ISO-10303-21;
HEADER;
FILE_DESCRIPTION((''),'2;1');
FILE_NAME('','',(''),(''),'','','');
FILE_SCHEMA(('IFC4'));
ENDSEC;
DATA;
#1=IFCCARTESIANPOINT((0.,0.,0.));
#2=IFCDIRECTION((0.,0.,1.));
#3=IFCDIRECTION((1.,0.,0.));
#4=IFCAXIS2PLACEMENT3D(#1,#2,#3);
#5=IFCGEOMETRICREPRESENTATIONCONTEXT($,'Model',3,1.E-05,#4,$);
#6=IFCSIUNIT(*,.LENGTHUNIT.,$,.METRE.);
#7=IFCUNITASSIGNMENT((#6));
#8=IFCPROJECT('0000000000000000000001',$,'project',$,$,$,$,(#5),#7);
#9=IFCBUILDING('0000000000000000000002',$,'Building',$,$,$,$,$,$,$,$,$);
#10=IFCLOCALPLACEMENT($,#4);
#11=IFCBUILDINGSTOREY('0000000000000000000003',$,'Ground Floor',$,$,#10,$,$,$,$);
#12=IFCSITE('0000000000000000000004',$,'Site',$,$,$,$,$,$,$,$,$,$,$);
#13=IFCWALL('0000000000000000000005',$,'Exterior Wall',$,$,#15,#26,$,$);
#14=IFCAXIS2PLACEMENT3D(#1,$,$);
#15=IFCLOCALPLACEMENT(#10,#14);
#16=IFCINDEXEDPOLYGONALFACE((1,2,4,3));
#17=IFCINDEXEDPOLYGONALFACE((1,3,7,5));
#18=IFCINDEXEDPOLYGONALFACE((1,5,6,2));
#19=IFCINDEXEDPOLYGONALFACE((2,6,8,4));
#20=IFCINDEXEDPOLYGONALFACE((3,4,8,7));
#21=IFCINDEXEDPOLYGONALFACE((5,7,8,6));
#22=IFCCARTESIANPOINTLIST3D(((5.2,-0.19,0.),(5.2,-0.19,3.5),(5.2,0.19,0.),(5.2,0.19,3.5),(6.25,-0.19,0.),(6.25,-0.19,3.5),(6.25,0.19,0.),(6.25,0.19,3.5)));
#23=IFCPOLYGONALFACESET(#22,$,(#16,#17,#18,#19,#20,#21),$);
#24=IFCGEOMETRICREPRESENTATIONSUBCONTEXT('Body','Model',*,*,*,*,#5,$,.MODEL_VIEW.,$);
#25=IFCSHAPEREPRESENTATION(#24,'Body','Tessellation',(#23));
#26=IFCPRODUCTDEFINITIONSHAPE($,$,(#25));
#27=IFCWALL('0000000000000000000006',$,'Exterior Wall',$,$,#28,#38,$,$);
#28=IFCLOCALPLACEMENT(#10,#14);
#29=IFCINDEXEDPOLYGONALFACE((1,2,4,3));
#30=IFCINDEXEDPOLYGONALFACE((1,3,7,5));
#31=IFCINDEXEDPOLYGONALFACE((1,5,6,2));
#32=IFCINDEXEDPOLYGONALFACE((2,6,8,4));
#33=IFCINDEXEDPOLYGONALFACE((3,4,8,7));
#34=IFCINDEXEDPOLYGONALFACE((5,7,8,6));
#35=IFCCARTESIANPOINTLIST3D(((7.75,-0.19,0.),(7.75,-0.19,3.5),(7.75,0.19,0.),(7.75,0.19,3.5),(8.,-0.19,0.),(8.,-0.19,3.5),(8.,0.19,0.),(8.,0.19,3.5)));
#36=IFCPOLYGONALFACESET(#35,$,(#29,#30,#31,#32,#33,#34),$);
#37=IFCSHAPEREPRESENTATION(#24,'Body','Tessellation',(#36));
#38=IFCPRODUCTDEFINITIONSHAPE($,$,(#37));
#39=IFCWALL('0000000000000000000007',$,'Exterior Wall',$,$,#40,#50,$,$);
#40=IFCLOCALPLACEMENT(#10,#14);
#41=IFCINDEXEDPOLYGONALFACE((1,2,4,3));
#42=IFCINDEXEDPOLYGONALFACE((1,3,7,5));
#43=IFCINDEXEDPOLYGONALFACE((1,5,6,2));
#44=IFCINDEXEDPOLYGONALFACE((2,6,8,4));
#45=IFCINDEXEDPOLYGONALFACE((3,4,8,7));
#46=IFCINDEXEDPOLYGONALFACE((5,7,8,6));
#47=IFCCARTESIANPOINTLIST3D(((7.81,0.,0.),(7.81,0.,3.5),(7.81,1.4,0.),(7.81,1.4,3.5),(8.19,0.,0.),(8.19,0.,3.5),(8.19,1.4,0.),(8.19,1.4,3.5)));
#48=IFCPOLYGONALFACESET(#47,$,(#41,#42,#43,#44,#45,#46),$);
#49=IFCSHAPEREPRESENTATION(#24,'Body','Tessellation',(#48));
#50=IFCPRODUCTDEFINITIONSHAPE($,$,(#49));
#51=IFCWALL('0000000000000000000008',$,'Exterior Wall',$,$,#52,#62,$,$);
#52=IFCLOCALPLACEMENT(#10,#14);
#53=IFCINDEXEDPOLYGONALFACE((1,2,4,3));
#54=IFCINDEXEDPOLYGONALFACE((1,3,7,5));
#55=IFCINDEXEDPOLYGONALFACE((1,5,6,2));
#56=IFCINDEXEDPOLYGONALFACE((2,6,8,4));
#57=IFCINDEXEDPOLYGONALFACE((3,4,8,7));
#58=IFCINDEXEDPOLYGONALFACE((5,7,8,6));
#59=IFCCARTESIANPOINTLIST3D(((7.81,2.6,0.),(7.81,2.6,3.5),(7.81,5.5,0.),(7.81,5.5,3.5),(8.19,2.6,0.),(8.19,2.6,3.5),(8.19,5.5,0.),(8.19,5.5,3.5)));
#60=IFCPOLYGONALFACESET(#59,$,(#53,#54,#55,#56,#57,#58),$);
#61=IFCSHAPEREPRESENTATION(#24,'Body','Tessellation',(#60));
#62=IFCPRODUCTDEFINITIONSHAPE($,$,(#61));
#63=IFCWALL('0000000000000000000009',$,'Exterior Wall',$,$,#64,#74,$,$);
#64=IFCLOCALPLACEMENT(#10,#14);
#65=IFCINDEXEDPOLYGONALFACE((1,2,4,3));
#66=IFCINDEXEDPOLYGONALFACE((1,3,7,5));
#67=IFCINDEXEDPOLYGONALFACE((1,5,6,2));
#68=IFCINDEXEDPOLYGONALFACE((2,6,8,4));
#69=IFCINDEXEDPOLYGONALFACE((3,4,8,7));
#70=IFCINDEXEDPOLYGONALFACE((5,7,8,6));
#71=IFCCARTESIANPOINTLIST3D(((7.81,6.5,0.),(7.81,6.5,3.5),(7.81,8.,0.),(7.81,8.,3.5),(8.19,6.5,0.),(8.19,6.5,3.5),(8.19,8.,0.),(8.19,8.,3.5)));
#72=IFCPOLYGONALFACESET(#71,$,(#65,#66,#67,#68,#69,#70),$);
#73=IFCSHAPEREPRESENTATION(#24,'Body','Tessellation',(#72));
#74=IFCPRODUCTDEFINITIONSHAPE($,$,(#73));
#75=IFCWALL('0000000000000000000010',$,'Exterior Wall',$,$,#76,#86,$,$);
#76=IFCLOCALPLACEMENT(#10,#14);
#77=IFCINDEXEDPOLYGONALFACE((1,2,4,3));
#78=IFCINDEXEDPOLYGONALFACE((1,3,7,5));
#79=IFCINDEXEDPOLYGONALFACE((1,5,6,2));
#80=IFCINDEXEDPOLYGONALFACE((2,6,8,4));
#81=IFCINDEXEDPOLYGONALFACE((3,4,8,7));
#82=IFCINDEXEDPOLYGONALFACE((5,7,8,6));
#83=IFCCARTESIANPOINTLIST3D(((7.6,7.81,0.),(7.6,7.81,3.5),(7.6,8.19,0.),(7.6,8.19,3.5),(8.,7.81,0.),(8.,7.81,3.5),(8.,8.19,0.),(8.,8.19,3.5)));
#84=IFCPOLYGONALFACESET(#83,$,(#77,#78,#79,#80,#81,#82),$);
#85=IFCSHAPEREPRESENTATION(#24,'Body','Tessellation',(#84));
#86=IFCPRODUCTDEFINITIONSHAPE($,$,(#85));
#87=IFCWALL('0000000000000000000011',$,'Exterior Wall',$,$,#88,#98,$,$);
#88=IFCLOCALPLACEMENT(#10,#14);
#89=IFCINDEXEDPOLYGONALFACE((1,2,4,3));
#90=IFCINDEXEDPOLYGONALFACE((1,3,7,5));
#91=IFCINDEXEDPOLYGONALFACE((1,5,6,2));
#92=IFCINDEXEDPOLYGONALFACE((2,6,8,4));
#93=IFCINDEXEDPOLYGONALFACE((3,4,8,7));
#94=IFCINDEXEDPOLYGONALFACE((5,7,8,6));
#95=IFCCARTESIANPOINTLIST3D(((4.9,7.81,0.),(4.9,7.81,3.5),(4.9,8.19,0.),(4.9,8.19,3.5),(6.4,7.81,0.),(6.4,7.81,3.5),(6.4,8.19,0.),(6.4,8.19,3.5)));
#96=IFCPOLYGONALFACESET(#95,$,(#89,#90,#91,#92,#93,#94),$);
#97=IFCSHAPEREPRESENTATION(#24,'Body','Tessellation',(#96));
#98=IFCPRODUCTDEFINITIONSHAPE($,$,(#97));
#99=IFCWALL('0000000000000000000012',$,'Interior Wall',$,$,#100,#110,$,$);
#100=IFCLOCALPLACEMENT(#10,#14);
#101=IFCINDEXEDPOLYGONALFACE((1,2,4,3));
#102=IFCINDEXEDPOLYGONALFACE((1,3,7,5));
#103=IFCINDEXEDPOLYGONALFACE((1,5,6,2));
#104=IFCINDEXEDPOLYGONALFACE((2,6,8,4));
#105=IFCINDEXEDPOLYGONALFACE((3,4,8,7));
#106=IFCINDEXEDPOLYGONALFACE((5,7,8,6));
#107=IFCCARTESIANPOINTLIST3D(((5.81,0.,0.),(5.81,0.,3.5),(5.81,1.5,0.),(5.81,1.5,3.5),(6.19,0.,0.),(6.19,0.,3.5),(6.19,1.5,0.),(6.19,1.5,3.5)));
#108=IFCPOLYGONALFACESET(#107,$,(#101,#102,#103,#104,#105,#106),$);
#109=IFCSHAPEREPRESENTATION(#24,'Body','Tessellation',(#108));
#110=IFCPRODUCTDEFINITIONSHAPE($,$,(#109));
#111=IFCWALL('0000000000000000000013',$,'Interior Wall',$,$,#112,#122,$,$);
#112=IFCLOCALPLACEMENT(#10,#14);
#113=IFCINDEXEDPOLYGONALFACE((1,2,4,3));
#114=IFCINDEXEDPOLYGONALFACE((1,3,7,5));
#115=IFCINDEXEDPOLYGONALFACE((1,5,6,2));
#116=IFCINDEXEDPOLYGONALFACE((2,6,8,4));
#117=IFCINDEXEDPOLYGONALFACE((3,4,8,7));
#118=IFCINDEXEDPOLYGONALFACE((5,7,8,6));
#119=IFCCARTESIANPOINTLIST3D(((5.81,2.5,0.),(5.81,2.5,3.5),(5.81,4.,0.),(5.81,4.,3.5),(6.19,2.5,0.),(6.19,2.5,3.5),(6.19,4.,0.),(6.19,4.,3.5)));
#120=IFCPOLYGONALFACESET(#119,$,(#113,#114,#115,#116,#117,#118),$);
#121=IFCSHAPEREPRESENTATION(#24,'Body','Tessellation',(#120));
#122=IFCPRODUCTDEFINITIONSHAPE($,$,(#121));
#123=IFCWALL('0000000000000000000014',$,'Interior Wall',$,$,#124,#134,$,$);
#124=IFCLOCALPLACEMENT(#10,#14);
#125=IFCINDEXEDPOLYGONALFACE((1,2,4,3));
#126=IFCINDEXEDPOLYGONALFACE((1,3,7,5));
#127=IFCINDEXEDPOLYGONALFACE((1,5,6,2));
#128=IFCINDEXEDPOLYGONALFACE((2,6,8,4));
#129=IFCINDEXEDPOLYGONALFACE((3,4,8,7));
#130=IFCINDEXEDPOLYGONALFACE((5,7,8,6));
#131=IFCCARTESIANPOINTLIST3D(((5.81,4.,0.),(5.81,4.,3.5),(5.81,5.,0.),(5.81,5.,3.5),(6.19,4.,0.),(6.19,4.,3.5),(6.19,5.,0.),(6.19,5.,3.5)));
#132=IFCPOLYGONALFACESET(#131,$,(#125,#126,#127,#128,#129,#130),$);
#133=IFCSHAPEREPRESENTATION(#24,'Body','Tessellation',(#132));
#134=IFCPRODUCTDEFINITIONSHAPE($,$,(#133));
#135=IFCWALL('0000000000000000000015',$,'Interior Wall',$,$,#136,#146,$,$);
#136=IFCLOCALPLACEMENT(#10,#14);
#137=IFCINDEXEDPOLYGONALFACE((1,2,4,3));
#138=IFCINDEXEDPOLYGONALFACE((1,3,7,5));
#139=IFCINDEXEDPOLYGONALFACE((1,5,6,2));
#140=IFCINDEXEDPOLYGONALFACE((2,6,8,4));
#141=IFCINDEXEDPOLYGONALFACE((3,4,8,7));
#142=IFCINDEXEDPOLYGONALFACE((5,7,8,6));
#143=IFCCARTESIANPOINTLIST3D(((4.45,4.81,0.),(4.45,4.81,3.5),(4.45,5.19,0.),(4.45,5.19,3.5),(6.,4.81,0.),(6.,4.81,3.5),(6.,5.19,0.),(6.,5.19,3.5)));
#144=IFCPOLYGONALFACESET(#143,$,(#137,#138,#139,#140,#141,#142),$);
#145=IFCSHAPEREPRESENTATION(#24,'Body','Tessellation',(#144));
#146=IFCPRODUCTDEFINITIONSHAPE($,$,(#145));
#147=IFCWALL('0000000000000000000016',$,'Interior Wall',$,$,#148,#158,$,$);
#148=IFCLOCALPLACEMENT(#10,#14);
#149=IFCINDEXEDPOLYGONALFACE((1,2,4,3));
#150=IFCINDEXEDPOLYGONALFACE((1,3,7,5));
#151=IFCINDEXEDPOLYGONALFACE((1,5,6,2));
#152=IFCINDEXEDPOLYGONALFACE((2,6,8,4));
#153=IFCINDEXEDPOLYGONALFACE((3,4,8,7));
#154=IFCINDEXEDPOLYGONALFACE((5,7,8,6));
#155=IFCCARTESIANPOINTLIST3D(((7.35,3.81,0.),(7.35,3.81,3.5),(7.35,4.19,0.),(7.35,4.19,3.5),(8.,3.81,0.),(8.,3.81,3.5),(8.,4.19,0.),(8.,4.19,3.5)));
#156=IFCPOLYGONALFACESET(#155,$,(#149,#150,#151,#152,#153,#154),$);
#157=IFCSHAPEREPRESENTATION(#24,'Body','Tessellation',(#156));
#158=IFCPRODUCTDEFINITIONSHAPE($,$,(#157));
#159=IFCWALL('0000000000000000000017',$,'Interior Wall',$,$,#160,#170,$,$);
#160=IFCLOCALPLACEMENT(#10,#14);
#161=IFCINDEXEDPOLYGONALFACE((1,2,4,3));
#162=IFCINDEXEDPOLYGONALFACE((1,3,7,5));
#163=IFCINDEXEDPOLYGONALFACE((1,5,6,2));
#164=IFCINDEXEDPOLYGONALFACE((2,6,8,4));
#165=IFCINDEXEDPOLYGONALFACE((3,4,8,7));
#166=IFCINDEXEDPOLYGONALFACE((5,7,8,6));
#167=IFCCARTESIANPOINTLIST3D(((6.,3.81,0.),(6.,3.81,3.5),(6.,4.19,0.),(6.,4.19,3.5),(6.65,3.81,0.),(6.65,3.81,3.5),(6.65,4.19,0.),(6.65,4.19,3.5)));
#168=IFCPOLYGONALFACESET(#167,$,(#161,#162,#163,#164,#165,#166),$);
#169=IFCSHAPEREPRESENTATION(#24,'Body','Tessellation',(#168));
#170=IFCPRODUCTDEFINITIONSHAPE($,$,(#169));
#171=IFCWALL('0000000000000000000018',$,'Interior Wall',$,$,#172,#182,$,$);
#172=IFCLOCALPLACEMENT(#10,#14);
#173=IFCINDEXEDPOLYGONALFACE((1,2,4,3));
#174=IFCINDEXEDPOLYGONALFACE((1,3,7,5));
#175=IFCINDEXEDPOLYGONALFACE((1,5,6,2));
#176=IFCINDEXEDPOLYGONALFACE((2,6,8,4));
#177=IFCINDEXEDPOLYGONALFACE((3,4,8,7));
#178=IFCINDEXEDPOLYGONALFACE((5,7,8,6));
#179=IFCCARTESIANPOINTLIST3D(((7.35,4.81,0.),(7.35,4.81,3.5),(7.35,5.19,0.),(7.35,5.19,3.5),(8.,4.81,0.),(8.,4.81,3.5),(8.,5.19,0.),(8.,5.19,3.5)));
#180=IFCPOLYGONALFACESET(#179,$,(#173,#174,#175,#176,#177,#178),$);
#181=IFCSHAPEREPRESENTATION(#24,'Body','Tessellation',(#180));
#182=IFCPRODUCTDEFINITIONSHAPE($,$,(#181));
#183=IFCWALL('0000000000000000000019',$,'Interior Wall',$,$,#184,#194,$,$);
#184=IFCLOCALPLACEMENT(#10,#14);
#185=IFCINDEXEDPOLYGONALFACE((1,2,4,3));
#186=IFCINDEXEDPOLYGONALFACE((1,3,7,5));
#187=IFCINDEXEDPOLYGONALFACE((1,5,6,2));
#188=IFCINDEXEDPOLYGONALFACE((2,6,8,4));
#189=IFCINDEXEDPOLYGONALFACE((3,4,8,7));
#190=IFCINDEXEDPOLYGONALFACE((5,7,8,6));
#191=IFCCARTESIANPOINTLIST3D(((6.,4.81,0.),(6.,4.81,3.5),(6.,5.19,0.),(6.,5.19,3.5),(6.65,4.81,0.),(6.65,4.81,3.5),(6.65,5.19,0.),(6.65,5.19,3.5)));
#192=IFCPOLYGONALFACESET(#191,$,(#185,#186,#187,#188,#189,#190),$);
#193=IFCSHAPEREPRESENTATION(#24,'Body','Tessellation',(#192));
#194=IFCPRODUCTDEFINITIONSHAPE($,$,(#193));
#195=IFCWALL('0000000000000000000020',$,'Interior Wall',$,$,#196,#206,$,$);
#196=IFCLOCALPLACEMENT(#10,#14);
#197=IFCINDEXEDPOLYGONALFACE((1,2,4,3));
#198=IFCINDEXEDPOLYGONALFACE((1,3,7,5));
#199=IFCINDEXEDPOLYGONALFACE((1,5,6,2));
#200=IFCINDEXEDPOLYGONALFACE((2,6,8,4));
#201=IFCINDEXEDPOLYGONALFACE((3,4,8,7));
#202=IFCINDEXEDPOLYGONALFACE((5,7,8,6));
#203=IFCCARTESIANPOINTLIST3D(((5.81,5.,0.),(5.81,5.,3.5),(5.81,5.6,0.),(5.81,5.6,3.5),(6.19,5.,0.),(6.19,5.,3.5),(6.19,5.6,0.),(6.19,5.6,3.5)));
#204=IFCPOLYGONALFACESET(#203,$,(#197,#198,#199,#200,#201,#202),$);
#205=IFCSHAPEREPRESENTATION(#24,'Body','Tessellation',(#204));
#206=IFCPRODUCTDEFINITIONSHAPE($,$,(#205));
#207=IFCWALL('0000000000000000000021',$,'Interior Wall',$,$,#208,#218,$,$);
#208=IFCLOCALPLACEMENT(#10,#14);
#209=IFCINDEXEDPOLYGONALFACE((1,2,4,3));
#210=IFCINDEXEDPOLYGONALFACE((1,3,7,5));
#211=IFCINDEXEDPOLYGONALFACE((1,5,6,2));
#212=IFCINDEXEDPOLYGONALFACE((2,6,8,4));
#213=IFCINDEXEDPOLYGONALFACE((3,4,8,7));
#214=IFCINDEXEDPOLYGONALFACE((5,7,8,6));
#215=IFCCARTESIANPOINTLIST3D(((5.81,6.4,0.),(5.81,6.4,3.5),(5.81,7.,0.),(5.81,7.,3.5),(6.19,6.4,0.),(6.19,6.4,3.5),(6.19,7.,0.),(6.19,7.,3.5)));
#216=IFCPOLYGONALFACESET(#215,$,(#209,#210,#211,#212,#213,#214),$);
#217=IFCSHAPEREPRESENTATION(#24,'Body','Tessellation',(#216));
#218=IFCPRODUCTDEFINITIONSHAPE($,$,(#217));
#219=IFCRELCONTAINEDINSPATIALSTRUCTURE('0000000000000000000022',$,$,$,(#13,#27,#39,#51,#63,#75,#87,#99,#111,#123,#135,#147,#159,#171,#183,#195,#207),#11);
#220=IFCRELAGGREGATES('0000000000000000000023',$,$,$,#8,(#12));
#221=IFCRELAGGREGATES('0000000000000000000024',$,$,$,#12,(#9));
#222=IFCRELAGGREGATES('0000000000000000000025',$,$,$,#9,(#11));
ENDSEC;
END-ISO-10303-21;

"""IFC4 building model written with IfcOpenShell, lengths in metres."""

from ifc_helpers import new_model, si_unit, frame, origin_with_axes, place, context, subcontext, project, spatial, indexed_curve, outline, extrude, element, save


model = new_model("IFC4")

# Units and contexts
model_context = context("Model", 3, precision=1e-05, world=origin_with_axes())
body_context = subcontext(model_context, "Body", "Model", "MODEL_VIEW")
ifc_project = project(units=[si_unit("LENGTHUNIT", "METRE")], contexts=[model_context])

# Site, building, storey
site = spatial("IfcSite", under=ifc_project, Name="Site")
building = spatial("IfcBuilding", under=site, Name="Building")
storey_placement = place(None, origin_with_axes())
storey = spatial("IfcBuildingStorey", under=building, at=storey_placement, Name="Ground Floor")

# Walls
wall_1_placement = place(storey_placement, frame((5.2, 0.0, 0.0), z_axis=(0.0, 0.0, 1.0), x_axis=(1.0, 0.0, 0.0)))
element("IfcWall", 1, at=wall_1_placement, inside=storey, Name="Exterior Wall", context=body_context, shape_type="SweptSolid", body=[
    extrude(outline(indexed_curve([(0.0, 0.0), (0.0, 0.38), (1.05, 0.38), (1.05, 0.0), (0.0, 0.0)], self_intersect=False)), frame((0.0, -0.19, 0.0), z_axis=(0.0, 0.0, 1.0), x_axis=(1.0, 0.0, 0.0)), (0.0, 0.0, 1.0), 3.5),
])
wall_2_placement = place(storey_placement, frame((7.75, 0.0, 0.0), z_axis=(0.0, 0.0, 1.0), x_axis=(1.0, 0.0, 0.0)))
element("IfcWall", 2, at=wall_2_placement, inside=storey, Name="Exterior Wall", context=body_context, shape_type="SweptSolid", body=[
    extrude(outline(indexed_curve([(0.0, 0.0), (0.0, 0.38), (0.25, 0.38), (0.25, 0.0), (0.0, 0.0)], self_intersect=False)), frame((0.0, -0.19, 0.0), z_axis=(0.0, 0.0, 1.0), x_axis=(1.0, 0.0, 0.0)), (0.0, 0.0, 1.0), 3.5),
])
wall_3_placement = place(storey_placement, frame((8.0, 0.0, 0.0), z_axis=(0.0, 0.0, 1.0), x_axis=(0.0, 1.0, 0.0)))
element("IfcWall", 3, at=wall_3_placement, inside=storey, Name="Exterior Wall", context=body_context, shape_type="SweptSolid", body=[
    extrude(outline(indexed_curve([(0.0, 0.0), (0.0, 0.38), (1.4, 0.38), (1.4, 0.0), (0.0, 0.0)], self_intersect=False)), frame((0.0, -0.19, 0.0), z_axis=(0.0, 0.0, 1.0), x_axis=(1.0, 0.0, 0.0)), (0.0, 0.0, 1.0), 3.5),
])
wall_4_placement = place(storey_placement, frame((8.0, 2.6, 0.0), z_axis=(0.0, 0.0, 1.0), x_axis=(0.0, 1.0, 0.0)))
element("IfcWall", 4, at=wall_4_placement, inside=storey, Name="Exterior Wall", context=body_context, shape_type="SweptSolid", body=[
    extrude(outline(indexed_curve([(0.0, 0.0), (0.0, 0.38), (2.9, 0.38), (2.9, 0.0), (0.0, 0.0)], self_intersect=False)), frame((0.0, -0.19, 0.0), z_axis=(0.0, 0.0, 1.0), x_axis=(1.0, 0.0, 0.0)), (0.0, 0.0, 1.0), 3.5),
])
wall_5_placement = place(storey_placement, frame((8.0, 6.5, 0.0), z_axis=(0.0, 0.0, 1.0), x_axis=(0.0, 1.0, 0.0)))
element("IfcWall", 5, at=wall_5_placement, inside=storey, Name="Exterior Wall", context=body_context, shape_type="SweptSolid", body=[
    extrude(outline(indexed_curve([(0.0, 0.0), (0.0, 0.38), (1.5, 0.38), (1.5, 0.0), (0.0, 0.0)], self_intersect=False)), frame((0.0, -0.19, 0.0), z_axis=(0.0, 0.0, 1.0), x_axis=(1.0, 0.0, 0.0)), (0.0, 0.0, 1.0), 3.5),
])
wall_6_placement = place(storey_placement, frame((8.0, 8.0, 0.0), z_axis=(0.0, 0.0, 1.0), x_axis=(-1.0, 0.0, 0.0)))
element("IfcWall", 6, at=wall_6_placement, inside=storey, Name="Exterior Wall", context=body_context, shape_type="SweptSolid", body=[
    extrude(outline(indexed_curve([(0.0, 0.0), (0.0, 0.38), (0.4, 0.38), (0.4, 0.0), (0.0, 0.0)], self_intersect=False)), frame((0.0, -0.19, 0.0), z_axis=(0.0, 0.0, 1.0), x_axis=(1.0, 0.0, 0.0)), (0.0, 0.0, 1.0), 3.5),
])
for number, where, z_axis, x_axis, name in (
    (7, (6.4, 8.0, 0.0), (0.0, 0.0, 1.0), (-1.0, 0.0, 0.0), "Exterior Wall"),
    (8, (6.0, 0.0, 0.0), (0.0, 0.0, 1.0), (0.0, 1.0, 0.0), "Interior Wall"),
    (9, (6.0, 2.5, 0.0), (0.0, 0.0, 1.0), (0.0, 1.0, 0.0), "Interior Wall"),
):
    element("IfcWall", number, at=place(storey_placement, frame(where, z_axis=z_axis, x_axis=x_axis)), inside=storey, Name=name, context=body_context, shape_type="SweptSolid", body=[
        extrude(outline(indexed_curve([(0.0, 0.0), (0.0, 0.38), (1.5, 0.38), (1.5, 0.0), (0.0, 0.0)], self_intersect=False)), frame((0.0, -0.19, 0.0), z_axis=(0.0, 0.0, 1.0), x_axis=(1.0, 0.0, 0.0)), (0.0, 0.0, 1.0), 3.5),
    ])
wall_7_placement = place(storey_placement, frame((6.0, 4.0, 0.0), z_axis=(0.0, 0.0, 1.0), x_axis=(0.0, 1.0, 0.0)))
element("IfcWall", 10, at=wall_7_placement, inside=storey, Name="Interior Wall", context=body_context, shape_type="SweptSolid", body=[
    extrude(outline(indexed_curve([(0.0, 0.0), (0.0, 0.38), (1.0, 0.38), (1.0, 0.0), (0.0, 0.0)], self_intersect=False)), frame((0.0, -0.19, 0.0), z_axis=(0.0, 0.0, 1.0), x_axis=(1.0, 0.0, 0.0)), (0.0, 0.0, 1.0), 3.5),
])
wall_8_placement = place(storey_placement, frame((6.0, 5.0, 0.0), z_axis=(0.0, 0.0, 1.0), x_axis=(-1.0, 0.0, 0.0)))
element("IfcWall", 11, at=wall_8_placement, inside=storey, Name="Interior Wall", context=body_context, shape_type="SweptSolid", body=[
    extrude(outline(indexed_curve([(0.0, 0.0), (0.0, 0.38), (1.55, 0.38), (1.55, 0.0), (0.0, 0.0)], self_intersect=False)), frame((0.0, -0.19, 0.0), z_axis=(0.0, 0.0, 1.0), x_axis=(1.0, 0.0, 0.0)), (0.0, 0.0, 1.0), 3.5),
])
for number, where, z_axis, x_axis, name in (
    (12, (8.0, 4.0, 0.0), (0.0, 0.0, 1.0), (-1.0, 0.0, 0.0), "Interior Wall"),
    (13, (6.65, 4.0, 0.0), (0.0, 0.0, 1.0), (-1.0, 0.0, 0.0), "Interior Wall"),
    (14, (8.0, 5.0, 0.0), (0.0, 0.0, 1.0), (-1.0, 0.0, 0.0), "Interior Wall"),
    (15, (6.65, 5.0, 0.0), (0.0, 0.0, 1.0), (-1.0, 0.0, 0.0), "Interior Wall"),
):
    element("IfcWall", number, at=place(storey_placement, frame(where, z_axis=z_axis, x_axis=x_axis)), inside=storey, Name=name, context=body_context, shape_type="SweptSolid", body=[
        extrude(outline(indexed_curve([(0.0, 0.0), (0.0, 0.38), (0.65, 0.38), (0.65, 0.0), (0.0, 0.0)], self_intersect=False)), frame((0.0, -0.19, 0.0), z_axis=(0.0, 0.0, 1.0), x_axis=(1.0, 0.0, 0.0)), (0.0, 0.0, 1.0), 3.5),
    ])
for number, where, z_axis, x_axis, name in (
    (16, (6.0, 5.0, 0.0), (0.0, 0.0, 1.0), (0.0, 1.0, 0.0), "Interior Wall"),
    (17, (6.0, 6.4, 0.0), (0.0, 0.0, 1.0), (0.0, 1.0, 0.0), "Interior Wall"),
):
    element("IfcWall", number, at=place(storey_placement, frame(where, z_axis=z_axis, x_axis=x_axis)), inside=storey, Name=name, context=body_context, shape_type="SweptSolid", body=[
        extrude(outline(indexed_curve([(0.0, 0.0), (0.0, 0.38), (0.6, 0.38), (0.6, 0.0), (0.0, 0.0)], self_intersect=False)), frame((0.0, -0.19, 0.0), z_axis=(0.0, 0.0, 1.0), x_axis=(1.0, 0.0, 0.0)), (0.0, 0.0, 1.0), 3.5),
    ])

save(model, "model.ifc")
